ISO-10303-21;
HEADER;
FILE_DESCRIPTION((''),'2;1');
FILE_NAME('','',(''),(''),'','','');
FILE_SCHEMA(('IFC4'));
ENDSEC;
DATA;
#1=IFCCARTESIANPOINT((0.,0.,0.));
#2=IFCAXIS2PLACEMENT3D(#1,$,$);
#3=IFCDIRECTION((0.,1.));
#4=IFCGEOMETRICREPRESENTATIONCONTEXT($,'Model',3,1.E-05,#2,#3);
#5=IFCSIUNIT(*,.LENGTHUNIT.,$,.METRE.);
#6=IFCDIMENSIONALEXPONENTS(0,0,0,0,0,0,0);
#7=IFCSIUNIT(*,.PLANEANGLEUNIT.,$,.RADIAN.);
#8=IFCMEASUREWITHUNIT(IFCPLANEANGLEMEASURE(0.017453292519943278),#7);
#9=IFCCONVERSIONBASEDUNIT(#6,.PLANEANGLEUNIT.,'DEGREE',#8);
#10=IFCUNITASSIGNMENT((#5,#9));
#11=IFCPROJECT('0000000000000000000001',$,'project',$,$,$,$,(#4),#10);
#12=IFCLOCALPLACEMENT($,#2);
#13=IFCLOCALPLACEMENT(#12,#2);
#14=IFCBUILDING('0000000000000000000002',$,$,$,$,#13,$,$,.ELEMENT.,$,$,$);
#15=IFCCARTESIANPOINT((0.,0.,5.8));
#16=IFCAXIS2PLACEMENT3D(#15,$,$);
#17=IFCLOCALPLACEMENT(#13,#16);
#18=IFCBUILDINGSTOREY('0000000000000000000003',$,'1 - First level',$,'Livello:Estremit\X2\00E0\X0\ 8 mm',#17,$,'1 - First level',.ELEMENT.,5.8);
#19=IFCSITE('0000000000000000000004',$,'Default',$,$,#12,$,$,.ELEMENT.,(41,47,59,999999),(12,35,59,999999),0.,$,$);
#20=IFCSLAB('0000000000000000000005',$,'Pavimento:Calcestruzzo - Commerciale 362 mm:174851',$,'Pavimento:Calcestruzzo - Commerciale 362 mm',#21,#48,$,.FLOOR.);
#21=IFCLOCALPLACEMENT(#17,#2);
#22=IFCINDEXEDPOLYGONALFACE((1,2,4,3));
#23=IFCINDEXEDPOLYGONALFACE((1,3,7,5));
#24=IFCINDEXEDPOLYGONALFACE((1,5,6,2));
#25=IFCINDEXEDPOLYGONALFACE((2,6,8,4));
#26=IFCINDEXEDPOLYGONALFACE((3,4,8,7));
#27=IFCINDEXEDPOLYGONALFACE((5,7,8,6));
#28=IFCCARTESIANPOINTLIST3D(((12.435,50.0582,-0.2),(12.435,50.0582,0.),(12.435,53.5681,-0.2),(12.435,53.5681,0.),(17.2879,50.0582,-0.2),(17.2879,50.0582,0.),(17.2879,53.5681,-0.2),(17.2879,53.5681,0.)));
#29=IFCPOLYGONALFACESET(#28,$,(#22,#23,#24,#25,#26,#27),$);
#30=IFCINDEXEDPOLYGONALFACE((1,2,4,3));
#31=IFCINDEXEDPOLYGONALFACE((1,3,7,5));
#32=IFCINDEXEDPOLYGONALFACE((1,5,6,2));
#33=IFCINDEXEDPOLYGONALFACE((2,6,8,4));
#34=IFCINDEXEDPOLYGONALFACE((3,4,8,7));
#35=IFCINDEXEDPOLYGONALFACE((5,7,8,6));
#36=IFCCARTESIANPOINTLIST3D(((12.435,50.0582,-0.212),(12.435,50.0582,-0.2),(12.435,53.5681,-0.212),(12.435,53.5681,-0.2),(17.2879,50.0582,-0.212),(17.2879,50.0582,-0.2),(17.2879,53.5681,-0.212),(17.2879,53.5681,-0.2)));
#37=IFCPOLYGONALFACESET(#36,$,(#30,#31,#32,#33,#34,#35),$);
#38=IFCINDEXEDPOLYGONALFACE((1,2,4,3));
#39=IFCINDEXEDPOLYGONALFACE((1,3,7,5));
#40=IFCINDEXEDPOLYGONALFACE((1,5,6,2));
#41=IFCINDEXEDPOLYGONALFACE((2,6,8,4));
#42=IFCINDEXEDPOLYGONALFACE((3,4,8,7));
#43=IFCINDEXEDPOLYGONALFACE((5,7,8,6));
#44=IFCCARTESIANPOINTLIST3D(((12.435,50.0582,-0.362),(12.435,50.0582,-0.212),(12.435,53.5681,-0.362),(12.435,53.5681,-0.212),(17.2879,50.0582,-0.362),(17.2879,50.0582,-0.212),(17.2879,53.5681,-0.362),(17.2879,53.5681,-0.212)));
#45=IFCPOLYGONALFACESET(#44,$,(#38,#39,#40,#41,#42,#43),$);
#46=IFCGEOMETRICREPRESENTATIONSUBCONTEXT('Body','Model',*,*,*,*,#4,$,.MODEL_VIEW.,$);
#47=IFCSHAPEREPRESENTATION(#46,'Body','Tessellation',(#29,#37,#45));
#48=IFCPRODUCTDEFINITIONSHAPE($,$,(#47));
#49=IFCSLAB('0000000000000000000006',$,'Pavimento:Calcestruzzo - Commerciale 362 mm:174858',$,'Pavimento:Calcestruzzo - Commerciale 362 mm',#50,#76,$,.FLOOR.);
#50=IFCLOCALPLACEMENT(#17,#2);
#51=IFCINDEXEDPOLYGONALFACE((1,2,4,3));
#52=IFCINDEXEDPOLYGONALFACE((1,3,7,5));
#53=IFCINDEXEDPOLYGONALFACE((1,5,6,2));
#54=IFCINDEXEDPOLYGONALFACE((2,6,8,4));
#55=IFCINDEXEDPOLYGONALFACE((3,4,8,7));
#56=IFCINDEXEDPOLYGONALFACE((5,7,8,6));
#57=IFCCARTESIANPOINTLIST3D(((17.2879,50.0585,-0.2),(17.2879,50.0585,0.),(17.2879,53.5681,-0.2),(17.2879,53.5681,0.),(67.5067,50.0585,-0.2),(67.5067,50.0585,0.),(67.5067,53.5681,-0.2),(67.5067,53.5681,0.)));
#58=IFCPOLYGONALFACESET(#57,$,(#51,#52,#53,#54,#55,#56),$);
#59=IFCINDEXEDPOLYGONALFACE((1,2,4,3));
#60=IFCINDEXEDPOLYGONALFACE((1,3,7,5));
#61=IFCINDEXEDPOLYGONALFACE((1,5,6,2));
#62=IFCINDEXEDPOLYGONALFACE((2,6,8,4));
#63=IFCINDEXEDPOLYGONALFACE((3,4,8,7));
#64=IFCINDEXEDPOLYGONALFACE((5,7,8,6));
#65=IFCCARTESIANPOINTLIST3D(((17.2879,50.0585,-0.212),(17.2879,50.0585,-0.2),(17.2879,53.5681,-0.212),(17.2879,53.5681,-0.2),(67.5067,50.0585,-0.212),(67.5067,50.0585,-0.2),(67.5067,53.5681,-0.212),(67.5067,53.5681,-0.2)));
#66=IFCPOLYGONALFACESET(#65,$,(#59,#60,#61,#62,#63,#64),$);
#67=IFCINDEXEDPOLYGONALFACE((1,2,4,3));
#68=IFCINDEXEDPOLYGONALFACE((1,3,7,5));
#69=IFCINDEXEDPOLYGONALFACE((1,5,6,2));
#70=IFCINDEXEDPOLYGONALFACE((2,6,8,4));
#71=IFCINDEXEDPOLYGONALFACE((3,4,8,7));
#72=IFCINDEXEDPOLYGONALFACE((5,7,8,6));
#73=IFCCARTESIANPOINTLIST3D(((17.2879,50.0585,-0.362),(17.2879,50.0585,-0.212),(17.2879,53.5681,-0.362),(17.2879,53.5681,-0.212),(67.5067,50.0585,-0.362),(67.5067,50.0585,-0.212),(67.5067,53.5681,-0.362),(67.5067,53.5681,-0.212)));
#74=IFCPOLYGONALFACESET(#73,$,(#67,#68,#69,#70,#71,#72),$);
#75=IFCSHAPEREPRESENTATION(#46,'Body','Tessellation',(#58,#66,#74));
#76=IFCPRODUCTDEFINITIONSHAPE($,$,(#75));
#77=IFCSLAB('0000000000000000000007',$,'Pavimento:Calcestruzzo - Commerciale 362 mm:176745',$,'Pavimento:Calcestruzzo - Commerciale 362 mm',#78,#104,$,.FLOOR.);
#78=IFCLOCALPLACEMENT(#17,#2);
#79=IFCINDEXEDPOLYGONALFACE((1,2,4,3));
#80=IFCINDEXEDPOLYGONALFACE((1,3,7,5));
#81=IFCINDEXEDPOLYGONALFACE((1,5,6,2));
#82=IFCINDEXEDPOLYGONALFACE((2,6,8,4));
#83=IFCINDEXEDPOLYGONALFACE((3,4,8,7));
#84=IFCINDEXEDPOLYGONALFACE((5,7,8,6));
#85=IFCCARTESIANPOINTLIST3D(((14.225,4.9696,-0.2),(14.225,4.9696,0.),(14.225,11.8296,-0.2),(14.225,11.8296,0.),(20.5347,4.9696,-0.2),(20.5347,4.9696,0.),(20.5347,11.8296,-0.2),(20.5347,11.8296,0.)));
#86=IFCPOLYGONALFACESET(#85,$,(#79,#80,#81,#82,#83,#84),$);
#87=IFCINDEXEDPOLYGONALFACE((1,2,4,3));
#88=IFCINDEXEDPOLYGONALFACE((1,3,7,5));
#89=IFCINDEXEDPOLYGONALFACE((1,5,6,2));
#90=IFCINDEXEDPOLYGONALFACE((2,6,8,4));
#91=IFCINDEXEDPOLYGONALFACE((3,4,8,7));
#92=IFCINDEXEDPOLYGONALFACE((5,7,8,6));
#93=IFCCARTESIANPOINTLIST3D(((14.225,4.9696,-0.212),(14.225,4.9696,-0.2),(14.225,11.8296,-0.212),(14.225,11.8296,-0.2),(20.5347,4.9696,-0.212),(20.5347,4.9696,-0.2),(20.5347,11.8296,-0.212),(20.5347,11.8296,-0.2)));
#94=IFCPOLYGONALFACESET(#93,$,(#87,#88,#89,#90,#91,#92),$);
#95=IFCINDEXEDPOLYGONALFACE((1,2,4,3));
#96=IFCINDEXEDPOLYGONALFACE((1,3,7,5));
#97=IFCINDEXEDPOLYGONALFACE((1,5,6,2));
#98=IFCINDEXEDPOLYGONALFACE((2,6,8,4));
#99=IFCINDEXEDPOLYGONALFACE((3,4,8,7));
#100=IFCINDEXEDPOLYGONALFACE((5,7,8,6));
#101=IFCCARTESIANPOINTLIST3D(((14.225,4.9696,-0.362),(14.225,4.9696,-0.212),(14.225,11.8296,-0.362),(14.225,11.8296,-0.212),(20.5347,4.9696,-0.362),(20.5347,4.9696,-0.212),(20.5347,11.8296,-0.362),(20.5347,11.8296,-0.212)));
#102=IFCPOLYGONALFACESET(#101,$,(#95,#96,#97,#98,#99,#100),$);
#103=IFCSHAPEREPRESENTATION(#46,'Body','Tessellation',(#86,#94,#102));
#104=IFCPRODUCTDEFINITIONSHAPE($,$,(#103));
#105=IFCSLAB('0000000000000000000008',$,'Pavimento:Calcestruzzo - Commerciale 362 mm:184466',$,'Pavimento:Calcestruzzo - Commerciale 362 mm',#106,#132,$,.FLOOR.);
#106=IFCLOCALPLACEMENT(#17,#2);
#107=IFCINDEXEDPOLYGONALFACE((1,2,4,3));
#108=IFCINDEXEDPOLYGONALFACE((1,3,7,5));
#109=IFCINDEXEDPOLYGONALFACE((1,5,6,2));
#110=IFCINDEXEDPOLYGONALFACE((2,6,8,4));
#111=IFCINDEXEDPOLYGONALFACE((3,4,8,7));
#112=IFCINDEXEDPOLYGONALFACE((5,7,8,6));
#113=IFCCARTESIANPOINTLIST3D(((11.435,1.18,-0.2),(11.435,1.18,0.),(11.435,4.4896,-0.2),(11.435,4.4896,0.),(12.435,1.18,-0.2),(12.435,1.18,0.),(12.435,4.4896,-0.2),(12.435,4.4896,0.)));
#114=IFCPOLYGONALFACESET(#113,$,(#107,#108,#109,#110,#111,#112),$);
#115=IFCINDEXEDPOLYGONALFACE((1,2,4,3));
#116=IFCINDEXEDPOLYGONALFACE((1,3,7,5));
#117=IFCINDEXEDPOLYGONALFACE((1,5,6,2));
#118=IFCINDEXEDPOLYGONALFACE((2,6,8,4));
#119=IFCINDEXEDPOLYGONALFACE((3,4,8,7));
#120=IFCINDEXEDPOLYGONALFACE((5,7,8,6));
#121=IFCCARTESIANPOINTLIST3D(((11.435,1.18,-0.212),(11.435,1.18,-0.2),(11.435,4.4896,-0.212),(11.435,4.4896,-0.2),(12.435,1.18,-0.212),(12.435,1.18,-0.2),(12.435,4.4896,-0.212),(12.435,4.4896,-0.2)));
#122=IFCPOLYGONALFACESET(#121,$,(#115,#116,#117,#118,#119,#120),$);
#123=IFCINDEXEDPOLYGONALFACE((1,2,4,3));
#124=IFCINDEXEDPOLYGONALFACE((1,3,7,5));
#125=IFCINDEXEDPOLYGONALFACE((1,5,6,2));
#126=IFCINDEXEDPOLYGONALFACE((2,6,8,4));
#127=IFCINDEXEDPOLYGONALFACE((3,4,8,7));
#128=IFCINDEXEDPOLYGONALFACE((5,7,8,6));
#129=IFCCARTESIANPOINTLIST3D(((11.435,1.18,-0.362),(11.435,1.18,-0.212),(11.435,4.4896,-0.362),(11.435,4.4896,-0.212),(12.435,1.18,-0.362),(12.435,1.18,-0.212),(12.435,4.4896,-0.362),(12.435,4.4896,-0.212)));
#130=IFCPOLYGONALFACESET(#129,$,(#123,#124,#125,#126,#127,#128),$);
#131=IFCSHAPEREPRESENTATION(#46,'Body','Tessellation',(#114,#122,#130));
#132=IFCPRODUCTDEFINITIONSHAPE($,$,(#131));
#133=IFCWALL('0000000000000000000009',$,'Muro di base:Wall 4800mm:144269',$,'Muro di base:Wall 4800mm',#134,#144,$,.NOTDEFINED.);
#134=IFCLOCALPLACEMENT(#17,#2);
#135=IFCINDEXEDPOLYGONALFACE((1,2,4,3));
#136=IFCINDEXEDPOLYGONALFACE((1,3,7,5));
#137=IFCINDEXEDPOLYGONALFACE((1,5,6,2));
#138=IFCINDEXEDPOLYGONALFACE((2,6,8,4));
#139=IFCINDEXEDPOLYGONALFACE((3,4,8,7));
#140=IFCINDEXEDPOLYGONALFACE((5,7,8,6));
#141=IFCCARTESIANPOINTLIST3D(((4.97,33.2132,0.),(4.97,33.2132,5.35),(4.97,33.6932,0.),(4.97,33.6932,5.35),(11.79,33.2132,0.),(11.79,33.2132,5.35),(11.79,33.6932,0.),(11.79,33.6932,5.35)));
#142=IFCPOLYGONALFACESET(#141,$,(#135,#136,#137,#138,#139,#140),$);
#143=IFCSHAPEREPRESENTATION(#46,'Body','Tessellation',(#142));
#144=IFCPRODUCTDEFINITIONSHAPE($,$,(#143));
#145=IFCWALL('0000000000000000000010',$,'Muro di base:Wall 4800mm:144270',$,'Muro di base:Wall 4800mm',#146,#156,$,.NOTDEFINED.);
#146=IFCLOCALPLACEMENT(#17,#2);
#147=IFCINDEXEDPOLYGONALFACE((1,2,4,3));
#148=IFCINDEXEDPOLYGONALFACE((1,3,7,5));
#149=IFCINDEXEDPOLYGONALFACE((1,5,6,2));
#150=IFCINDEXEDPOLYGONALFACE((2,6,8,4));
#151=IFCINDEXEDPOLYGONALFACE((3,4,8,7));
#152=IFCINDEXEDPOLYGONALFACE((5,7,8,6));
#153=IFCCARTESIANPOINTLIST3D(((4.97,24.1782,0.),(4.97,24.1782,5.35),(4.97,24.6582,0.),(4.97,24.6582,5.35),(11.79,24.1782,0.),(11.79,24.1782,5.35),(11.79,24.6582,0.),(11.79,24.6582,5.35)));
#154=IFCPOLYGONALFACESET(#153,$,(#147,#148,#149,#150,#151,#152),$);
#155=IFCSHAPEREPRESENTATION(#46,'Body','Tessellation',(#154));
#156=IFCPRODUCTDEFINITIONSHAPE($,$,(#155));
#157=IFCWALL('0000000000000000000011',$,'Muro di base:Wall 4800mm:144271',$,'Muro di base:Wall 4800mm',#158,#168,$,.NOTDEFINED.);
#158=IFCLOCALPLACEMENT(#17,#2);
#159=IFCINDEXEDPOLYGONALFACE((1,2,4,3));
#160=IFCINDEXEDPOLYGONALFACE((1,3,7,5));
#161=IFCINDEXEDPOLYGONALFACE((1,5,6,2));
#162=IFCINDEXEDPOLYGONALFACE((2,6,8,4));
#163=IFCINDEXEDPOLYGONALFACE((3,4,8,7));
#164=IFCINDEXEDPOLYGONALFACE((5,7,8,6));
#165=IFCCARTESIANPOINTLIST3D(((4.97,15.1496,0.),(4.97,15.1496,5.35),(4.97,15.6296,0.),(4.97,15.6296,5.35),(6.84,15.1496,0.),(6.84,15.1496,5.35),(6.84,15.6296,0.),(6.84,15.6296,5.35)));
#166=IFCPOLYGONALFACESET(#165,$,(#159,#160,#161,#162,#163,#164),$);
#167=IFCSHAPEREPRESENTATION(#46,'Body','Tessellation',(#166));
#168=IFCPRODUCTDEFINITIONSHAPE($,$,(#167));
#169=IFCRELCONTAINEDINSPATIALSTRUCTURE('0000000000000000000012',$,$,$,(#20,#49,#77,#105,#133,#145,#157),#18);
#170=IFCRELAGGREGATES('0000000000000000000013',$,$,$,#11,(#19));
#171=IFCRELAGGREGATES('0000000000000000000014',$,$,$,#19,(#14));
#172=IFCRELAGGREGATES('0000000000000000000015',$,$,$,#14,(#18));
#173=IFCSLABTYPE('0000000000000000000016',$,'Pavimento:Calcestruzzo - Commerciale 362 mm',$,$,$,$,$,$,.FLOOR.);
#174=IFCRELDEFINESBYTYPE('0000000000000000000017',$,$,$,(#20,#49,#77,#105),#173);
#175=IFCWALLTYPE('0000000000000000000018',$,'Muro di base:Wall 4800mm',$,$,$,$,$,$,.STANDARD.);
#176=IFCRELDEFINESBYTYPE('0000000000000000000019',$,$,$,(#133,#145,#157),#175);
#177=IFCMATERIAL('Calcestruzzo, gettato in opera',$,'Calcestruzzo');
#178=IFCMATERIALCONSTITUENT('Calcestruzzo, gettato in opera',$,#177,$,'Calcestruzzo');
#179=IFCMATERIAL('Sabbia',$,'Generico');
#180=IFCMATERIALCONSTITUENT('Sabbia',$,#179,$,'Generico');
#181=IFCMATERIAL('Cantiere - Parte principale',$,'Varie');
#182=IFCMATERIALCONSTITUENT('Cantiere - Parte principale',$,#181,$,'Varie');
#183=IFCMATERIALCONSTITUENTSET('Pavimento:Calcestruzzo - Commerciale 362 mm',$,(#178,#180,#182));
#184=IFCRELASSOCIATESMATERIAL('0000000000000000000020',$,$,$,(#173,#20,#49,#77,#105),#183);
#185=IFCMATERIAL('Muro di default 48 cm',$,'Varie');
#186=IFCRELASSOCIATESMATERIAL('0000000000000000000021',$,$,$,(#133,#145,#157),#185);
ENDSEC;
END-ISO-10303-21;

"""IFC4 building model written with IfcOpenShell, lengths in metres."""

from ifc_helpers import new_model, entity, si_unit, converted_unit, direction, frame, origin, place, context, subcontext, project, spatial, indexed_curve, outline, extrude, material, constituent, constituent_set, type_object, element, save


model = new_model("IFC4")

# Units and contexts
model_context = context("Model", 3, precision=1e-05, world=origin(), true_north=direction((0.0, 1.0)))
body_context = subcontext(model_context, "Body", "Model", "MODEL_VIEW")
ifc_project = project(units=[si_unit("LENGTHUNIT", "METRE"), converted_unit("PLANEANGLEUNIT", "DEGREE", entity("IfcPlaneAngleMeasure", 0.017453292519943278), si_unit("PLANEANGLEUNIT", "RADIAN"), dimensions=[0, 0, 0, 0, 0, 0, 0])], contexts=[model_context])

# Site, building, storey
site_placement = place(None, origin())
site = spatial("IfcSite", under=ifc_project, at=site_placement, Name="Default", CompositionType="ELEMENT", RefLatitude=(41, 47, 59, 999999), RefLongitude=(12, 35, 59, 999999), RefElevation=0.0)
building_placement = place(site_placement, origin())
building = spatial("IfcBuilding", under=site, at=building_placement, CompositionType="ELEMENT")
storey_placement = place(building_placement, frame((0.0, 0.0, 5.8)))
storey = spatial("IfcBuildingStorey", under=building, at=storey_placement, Name="1 - First level", ObjectType="Livello:Estremità 8 mm", LongName="1 - First level", CompositionType="ELEMENT", Elevation=5.8)

# Slabs
ifc_material_1 = material(Name="Calcestruzzo, gettato in opera", Category="Calcestruzzo")
ifc_constituent_1 = constituent(ifc_material_1, Name="Calcestruzzo, gettato in opera", Category="Calcestruzzo")
ifc_material_2 = material(Name="Sabbia", Category="Generico")
ifc_constituent_2 = constituent(ifc_material_2, Name="Sabbia", Category="Generico")
ifc_material_3 = material(Name="Cantiere - Parte principale", Category="Varie")
ifc_constituent_3 = constituent(ifc_material_3, Name="Cantiere - Parte principale", Category="Varie")
ifc_constituent_set = constituent_set(constituents=[ifc_constituent_1, ifc_constituent_2, ifc_constituent_3], Name="Pavimento:Calcestruzzo - Commerciale 362 mm")
slab_type = type_object("IfcSlabType", Name="Pavimento:Calcestruzzo - Commerciale 362 mm", PredefinedType="FLOOR", material=ifc_constituent_set)
slab_1_placement = place(storey_placement, origin())
element("IfcSlab", 1, at=slab_1_placement, inside=storey, type_object=slab_type, material=ifc_constituent_set, Name="Pavimento:Calcestruzzo - Commerciale 362 mm:174851", ObjectType="Pavimento:Calcestruzzo - Commerciale 362 mm", PredefinedType="FLOOR", context=body_context, shape_type="SweptSolid", body=[
    extrude(outline(indexed_curve([(-1.755, -2.4265), (1.755, -2.4265), (1.755, 2.4265), (-1.755, 2.4265), (-1.755, -2.4265)], self_intersect=False)), frame((14.8615, 51.8132, -0.2), z_axis=(0.0, 0.0, 1.0), x_axis=(0.0, -1.0, 0.0)), (0.0, 0.0, 1.0), 0.2),
    extrude(outline(indexed_curve([(-1.755, -2.4265), (1.755, -2.4265), (1.755, 2.4265), (-1.755, 2.4265), (-1.755, -2.4265)], self_intersect=False)), frame((14.8615, 51.8132, -0.212), z_axis=(0.0, 0.0, 1.0), x_axis=(0.0, -1.0, 0.0)), (0.0, 0.0, 1.0), 0.012),
    extrude(outline(indexed_curve([(-1.755, -2.4265), (1.755, -2.4265), (1.755, 2.4265), (-1.755, 2.4265), (-1.755, -2.4265)], self_intersect=False)), frame((14.8615, 51.8132, -0.362), z_axis=(0.0, 0.0, 1.0), x_axis=(0.0, -1.0, 0.0)), (0.0, 0.0, 1.0), 0.15),
])
slab_2_placement = place(storey_placement, origin())
element("IfcSlab", 2, at=slab_2_placement, inside=storey, type_object=slab_type, material=ifc_constituent_set, Name="Pavimento:Calcestruzzo - Commerciale 362 mm:174858", ObjectType="Pavimento:Calcestruzzo - Commerciale 362 mm", PredefinedType="FLOOR", context=body_context, shape_type="SweptSolid", body=[
    extrude(outline(indexed_curve([(-1.7548, -25.1094), (1.7548, -25.1094), (1.7548, 25.1094), (-1.7548, 25.1094), (-1.7548, -25.1094)], self_intersect=False)), frame((42.3973, 51.8133, -0.2), z_axis=(0.0, 0.0, 1.0), x_axis=(0.0, -1.0, 0.0)), (0.0, 0.0, 1.0), 0.2),
    extrude(outline(indexed_curve([(-1.7548, -25.1094), (1.7548, -25.1094), (1.7548, 25.1094), (-1.7548, 25.1094), (-1.7548, -25.1094)], self_intersect=False)), frame((42.3973, 51.8133, -0.212), z_axis=(0.0, 0.0, 1.0), x_axis=(0.0, -1.0, 0.0)), (0.0, 0.0, 1.0), 0.012),
    extrude(outline(indexed_curve([(-1.7548, -25.1094), (1.7548, -25.1094), (1.7548, 25.1094), (-1.7548, 25.1094), (-1.7548, -25.1094)], self_intersect=False)), frame((42.3973, 51.8133, -0.362), z_axis=(0.0, 0.0, 1.0), x_axis=(0.0, -1.0, 0.0)), (0.0, 0.0, 1.0), 0.15),
])
slab_3_placement = place(storey_placement, origin())
element("IfcSlab", 3, at=slab_3_placement, inside=storey, type_object=slab_type, material=ifc_constituent_set, Name="Pavimento:Calcestruzzo - Commerciale 362 mm:176745", ObjectType="Pavimento:Calcestruzzo - Commerciale 362 mm", PredefinedType="FLOOR", context=body_context, shape_type="SweptSolid", body=[
    extrude(outline(indexed_curve([(-3.1548, -3.43), (3.1548, -3.43), (3.1548, 3.43), (-3.1548, 3.43), (-3.1548, -3.43)], self_intersect=False)), frame((17.3799, 8.3996, -0.2), z_axis=(0.0, 0.0, 1.0), x_axis=(-1.0, 0.0, 0.0)), (0.0, 0.0, 1.0), 0.2),
    extrude(outline(indexed_curve([(-3.1548, -3.43), (3.1548, -3.43), (3.1548, 3.43), (-3.1548, 3.43), (-3.1548, -3.43)], self_intersect=False)), frame((17.3799, 8.3996, -0.212), z_axis=(0.0, 0.0, 1.0), x_axis=(-1.0, 0.0, 0.0)), (0.0, 0.0, 1.0), 0.012),
    extrude(outline(indexed_curve([(-3.1548, -3.43), (3.1548, -3.43), (3.1548, 3.43), (-3.1548, 3.43), (-3.1548, -3.43)], self_intersect=False)), frame((17.3799, 8.3996, -0.362), z_axis=(0.0, 0.0, 1.0), x_axis=(-1.0, 0.0, 0.0)), (0.0, 0.0, 1.0), 0.15),
])
slab_4_placement = place(storey_placement, origin())
element("IfcSlab", 4, at=slab_4_placement, inside=storey, type_object=slab_type, material=ifc_constituent_set, Name="Pavimento:Calcestruzzo - Commerciale 362 mm:184466", ObjectType="Pavimento:Calcestruzzo - Commerciale 362 mm", PredefinedType="FLOOR", context=body_context, shape_type="SweptSolid", body=[
    extrude(outline(indexed_curve([(-1.6548, -0.5), (1.6548, -0.5), (1.6548, 0.5), (-1.6548, 0.5), (-1.6548, -0.5)], self_intersect=False)), frame((11.935, 2.8348, -0.2), z_axis=(0.0, 0.0, 1.0), x_axis=(0.0, 1.0, 0.0)), (0.0, 0.0, 1.0), 0.2),
    extrude(outline(indexed_curve([(-1.6548, -0.5), (1.6548, -0.5), (1.6548, 0.5), (-1.6548, 0.5), (-1.6548, -0.5)], self_intersect=False)), frame((11.935, 2.8348, -0.212), z_axis=(0.0, 0.0, 1.0), x_axis=(0.0, 1.0, 0.0)), (0.0, 0.0, 1.0), 0.012),
    extrude(outline(indexed_curve([(-1.6548, -0.5), (1.6548, -0.5), (1.6548, 0.5), (-1.6548, 0.5), (-1.6548, -0.5)], self_intersect=False)), frame((11.935, 2.8348, -0.362), z_axis=(0.0, 0.0, 1.0), x_axis=(0.0, 1.0, 0.0)), (0.0, 0.0, 1.0), 0.15),
])

# Walls
ifc_material_4 = material(Name="Muro di default 48 cm", Category="Varie")
wall_type = type_object("IfcWallType", Name="Muro di base:Wall 4800mm", PredefinedType="STANDARD")
wall_1_placement = place(storey_placement, frame((4.97, 33.4532, 0.0)))
element("IfcWall", 5, at=wall_1_placement, inside=storey, type_object=wall_type, material=ifc_material_4, Name="Muro di base:Wall 4800mm:144269", ObjectType="Muro di base:Wall 4800mm", PredefinedType="NOTDEFINED", context=body_context, shape_type="SweptSolid", body=[
    extrude(outline(indexed_curve([(6.82, 0.24), (0.0, 0.24), (0.0, -0.24), (6.82, -0.24), (6.82, 0.24)], self_intersect=False)), origin(), (0.0, 0.0, 1.0), 5.35),
])
wall_2_placement = place(storey_placement, frame((4.97, 24.4182, 0.0)))
element("IfcWall", 6, at=wall_2_placement, inside=storey, type_object=wall_type, material=ifc_material_4, Name="Muro di base:Wall 4800mm:144270", ObjectType="Muro di base:Wall 4800mm", PredefinedType="NOTDEFINED", context=body_context, shape_type="SweptSolid", body=[
    extrude(outline(indexed_curve([(6.82, 0.24), (0.0, 0.24), (0.0, -0.24), (6.82, -0.24), (6.82, 0.24)], self_intersect=False)), origin(), (0.0, 0.0, 1.0), 5.35),
])
wall_3_placement = place(storey_placement, frame((4.97, 15.3896, 0.0)))
element("IfcWall", 7, at=wall_3_placement, inside=storey, type_object=wall_type, material=ifc_material_4, Name="Muro di base:Wall 4800mm:144271", ObjectType="Muro di base:Wall 4800mm", PredefinedType="NOTDEFINED", context=body_context, shape_type="SweptSolid", body=[
    extrude(outline(indexed_curve([(1.87, 0.24), (0.0, 0.24), (0.0, -0.24), (1.87, -0.24), (1.87, 0.24)], self_intersect=False)), origin(), (0.0, 0.0, 1.0), 5.35),
])

save(model, "model.ifc")
